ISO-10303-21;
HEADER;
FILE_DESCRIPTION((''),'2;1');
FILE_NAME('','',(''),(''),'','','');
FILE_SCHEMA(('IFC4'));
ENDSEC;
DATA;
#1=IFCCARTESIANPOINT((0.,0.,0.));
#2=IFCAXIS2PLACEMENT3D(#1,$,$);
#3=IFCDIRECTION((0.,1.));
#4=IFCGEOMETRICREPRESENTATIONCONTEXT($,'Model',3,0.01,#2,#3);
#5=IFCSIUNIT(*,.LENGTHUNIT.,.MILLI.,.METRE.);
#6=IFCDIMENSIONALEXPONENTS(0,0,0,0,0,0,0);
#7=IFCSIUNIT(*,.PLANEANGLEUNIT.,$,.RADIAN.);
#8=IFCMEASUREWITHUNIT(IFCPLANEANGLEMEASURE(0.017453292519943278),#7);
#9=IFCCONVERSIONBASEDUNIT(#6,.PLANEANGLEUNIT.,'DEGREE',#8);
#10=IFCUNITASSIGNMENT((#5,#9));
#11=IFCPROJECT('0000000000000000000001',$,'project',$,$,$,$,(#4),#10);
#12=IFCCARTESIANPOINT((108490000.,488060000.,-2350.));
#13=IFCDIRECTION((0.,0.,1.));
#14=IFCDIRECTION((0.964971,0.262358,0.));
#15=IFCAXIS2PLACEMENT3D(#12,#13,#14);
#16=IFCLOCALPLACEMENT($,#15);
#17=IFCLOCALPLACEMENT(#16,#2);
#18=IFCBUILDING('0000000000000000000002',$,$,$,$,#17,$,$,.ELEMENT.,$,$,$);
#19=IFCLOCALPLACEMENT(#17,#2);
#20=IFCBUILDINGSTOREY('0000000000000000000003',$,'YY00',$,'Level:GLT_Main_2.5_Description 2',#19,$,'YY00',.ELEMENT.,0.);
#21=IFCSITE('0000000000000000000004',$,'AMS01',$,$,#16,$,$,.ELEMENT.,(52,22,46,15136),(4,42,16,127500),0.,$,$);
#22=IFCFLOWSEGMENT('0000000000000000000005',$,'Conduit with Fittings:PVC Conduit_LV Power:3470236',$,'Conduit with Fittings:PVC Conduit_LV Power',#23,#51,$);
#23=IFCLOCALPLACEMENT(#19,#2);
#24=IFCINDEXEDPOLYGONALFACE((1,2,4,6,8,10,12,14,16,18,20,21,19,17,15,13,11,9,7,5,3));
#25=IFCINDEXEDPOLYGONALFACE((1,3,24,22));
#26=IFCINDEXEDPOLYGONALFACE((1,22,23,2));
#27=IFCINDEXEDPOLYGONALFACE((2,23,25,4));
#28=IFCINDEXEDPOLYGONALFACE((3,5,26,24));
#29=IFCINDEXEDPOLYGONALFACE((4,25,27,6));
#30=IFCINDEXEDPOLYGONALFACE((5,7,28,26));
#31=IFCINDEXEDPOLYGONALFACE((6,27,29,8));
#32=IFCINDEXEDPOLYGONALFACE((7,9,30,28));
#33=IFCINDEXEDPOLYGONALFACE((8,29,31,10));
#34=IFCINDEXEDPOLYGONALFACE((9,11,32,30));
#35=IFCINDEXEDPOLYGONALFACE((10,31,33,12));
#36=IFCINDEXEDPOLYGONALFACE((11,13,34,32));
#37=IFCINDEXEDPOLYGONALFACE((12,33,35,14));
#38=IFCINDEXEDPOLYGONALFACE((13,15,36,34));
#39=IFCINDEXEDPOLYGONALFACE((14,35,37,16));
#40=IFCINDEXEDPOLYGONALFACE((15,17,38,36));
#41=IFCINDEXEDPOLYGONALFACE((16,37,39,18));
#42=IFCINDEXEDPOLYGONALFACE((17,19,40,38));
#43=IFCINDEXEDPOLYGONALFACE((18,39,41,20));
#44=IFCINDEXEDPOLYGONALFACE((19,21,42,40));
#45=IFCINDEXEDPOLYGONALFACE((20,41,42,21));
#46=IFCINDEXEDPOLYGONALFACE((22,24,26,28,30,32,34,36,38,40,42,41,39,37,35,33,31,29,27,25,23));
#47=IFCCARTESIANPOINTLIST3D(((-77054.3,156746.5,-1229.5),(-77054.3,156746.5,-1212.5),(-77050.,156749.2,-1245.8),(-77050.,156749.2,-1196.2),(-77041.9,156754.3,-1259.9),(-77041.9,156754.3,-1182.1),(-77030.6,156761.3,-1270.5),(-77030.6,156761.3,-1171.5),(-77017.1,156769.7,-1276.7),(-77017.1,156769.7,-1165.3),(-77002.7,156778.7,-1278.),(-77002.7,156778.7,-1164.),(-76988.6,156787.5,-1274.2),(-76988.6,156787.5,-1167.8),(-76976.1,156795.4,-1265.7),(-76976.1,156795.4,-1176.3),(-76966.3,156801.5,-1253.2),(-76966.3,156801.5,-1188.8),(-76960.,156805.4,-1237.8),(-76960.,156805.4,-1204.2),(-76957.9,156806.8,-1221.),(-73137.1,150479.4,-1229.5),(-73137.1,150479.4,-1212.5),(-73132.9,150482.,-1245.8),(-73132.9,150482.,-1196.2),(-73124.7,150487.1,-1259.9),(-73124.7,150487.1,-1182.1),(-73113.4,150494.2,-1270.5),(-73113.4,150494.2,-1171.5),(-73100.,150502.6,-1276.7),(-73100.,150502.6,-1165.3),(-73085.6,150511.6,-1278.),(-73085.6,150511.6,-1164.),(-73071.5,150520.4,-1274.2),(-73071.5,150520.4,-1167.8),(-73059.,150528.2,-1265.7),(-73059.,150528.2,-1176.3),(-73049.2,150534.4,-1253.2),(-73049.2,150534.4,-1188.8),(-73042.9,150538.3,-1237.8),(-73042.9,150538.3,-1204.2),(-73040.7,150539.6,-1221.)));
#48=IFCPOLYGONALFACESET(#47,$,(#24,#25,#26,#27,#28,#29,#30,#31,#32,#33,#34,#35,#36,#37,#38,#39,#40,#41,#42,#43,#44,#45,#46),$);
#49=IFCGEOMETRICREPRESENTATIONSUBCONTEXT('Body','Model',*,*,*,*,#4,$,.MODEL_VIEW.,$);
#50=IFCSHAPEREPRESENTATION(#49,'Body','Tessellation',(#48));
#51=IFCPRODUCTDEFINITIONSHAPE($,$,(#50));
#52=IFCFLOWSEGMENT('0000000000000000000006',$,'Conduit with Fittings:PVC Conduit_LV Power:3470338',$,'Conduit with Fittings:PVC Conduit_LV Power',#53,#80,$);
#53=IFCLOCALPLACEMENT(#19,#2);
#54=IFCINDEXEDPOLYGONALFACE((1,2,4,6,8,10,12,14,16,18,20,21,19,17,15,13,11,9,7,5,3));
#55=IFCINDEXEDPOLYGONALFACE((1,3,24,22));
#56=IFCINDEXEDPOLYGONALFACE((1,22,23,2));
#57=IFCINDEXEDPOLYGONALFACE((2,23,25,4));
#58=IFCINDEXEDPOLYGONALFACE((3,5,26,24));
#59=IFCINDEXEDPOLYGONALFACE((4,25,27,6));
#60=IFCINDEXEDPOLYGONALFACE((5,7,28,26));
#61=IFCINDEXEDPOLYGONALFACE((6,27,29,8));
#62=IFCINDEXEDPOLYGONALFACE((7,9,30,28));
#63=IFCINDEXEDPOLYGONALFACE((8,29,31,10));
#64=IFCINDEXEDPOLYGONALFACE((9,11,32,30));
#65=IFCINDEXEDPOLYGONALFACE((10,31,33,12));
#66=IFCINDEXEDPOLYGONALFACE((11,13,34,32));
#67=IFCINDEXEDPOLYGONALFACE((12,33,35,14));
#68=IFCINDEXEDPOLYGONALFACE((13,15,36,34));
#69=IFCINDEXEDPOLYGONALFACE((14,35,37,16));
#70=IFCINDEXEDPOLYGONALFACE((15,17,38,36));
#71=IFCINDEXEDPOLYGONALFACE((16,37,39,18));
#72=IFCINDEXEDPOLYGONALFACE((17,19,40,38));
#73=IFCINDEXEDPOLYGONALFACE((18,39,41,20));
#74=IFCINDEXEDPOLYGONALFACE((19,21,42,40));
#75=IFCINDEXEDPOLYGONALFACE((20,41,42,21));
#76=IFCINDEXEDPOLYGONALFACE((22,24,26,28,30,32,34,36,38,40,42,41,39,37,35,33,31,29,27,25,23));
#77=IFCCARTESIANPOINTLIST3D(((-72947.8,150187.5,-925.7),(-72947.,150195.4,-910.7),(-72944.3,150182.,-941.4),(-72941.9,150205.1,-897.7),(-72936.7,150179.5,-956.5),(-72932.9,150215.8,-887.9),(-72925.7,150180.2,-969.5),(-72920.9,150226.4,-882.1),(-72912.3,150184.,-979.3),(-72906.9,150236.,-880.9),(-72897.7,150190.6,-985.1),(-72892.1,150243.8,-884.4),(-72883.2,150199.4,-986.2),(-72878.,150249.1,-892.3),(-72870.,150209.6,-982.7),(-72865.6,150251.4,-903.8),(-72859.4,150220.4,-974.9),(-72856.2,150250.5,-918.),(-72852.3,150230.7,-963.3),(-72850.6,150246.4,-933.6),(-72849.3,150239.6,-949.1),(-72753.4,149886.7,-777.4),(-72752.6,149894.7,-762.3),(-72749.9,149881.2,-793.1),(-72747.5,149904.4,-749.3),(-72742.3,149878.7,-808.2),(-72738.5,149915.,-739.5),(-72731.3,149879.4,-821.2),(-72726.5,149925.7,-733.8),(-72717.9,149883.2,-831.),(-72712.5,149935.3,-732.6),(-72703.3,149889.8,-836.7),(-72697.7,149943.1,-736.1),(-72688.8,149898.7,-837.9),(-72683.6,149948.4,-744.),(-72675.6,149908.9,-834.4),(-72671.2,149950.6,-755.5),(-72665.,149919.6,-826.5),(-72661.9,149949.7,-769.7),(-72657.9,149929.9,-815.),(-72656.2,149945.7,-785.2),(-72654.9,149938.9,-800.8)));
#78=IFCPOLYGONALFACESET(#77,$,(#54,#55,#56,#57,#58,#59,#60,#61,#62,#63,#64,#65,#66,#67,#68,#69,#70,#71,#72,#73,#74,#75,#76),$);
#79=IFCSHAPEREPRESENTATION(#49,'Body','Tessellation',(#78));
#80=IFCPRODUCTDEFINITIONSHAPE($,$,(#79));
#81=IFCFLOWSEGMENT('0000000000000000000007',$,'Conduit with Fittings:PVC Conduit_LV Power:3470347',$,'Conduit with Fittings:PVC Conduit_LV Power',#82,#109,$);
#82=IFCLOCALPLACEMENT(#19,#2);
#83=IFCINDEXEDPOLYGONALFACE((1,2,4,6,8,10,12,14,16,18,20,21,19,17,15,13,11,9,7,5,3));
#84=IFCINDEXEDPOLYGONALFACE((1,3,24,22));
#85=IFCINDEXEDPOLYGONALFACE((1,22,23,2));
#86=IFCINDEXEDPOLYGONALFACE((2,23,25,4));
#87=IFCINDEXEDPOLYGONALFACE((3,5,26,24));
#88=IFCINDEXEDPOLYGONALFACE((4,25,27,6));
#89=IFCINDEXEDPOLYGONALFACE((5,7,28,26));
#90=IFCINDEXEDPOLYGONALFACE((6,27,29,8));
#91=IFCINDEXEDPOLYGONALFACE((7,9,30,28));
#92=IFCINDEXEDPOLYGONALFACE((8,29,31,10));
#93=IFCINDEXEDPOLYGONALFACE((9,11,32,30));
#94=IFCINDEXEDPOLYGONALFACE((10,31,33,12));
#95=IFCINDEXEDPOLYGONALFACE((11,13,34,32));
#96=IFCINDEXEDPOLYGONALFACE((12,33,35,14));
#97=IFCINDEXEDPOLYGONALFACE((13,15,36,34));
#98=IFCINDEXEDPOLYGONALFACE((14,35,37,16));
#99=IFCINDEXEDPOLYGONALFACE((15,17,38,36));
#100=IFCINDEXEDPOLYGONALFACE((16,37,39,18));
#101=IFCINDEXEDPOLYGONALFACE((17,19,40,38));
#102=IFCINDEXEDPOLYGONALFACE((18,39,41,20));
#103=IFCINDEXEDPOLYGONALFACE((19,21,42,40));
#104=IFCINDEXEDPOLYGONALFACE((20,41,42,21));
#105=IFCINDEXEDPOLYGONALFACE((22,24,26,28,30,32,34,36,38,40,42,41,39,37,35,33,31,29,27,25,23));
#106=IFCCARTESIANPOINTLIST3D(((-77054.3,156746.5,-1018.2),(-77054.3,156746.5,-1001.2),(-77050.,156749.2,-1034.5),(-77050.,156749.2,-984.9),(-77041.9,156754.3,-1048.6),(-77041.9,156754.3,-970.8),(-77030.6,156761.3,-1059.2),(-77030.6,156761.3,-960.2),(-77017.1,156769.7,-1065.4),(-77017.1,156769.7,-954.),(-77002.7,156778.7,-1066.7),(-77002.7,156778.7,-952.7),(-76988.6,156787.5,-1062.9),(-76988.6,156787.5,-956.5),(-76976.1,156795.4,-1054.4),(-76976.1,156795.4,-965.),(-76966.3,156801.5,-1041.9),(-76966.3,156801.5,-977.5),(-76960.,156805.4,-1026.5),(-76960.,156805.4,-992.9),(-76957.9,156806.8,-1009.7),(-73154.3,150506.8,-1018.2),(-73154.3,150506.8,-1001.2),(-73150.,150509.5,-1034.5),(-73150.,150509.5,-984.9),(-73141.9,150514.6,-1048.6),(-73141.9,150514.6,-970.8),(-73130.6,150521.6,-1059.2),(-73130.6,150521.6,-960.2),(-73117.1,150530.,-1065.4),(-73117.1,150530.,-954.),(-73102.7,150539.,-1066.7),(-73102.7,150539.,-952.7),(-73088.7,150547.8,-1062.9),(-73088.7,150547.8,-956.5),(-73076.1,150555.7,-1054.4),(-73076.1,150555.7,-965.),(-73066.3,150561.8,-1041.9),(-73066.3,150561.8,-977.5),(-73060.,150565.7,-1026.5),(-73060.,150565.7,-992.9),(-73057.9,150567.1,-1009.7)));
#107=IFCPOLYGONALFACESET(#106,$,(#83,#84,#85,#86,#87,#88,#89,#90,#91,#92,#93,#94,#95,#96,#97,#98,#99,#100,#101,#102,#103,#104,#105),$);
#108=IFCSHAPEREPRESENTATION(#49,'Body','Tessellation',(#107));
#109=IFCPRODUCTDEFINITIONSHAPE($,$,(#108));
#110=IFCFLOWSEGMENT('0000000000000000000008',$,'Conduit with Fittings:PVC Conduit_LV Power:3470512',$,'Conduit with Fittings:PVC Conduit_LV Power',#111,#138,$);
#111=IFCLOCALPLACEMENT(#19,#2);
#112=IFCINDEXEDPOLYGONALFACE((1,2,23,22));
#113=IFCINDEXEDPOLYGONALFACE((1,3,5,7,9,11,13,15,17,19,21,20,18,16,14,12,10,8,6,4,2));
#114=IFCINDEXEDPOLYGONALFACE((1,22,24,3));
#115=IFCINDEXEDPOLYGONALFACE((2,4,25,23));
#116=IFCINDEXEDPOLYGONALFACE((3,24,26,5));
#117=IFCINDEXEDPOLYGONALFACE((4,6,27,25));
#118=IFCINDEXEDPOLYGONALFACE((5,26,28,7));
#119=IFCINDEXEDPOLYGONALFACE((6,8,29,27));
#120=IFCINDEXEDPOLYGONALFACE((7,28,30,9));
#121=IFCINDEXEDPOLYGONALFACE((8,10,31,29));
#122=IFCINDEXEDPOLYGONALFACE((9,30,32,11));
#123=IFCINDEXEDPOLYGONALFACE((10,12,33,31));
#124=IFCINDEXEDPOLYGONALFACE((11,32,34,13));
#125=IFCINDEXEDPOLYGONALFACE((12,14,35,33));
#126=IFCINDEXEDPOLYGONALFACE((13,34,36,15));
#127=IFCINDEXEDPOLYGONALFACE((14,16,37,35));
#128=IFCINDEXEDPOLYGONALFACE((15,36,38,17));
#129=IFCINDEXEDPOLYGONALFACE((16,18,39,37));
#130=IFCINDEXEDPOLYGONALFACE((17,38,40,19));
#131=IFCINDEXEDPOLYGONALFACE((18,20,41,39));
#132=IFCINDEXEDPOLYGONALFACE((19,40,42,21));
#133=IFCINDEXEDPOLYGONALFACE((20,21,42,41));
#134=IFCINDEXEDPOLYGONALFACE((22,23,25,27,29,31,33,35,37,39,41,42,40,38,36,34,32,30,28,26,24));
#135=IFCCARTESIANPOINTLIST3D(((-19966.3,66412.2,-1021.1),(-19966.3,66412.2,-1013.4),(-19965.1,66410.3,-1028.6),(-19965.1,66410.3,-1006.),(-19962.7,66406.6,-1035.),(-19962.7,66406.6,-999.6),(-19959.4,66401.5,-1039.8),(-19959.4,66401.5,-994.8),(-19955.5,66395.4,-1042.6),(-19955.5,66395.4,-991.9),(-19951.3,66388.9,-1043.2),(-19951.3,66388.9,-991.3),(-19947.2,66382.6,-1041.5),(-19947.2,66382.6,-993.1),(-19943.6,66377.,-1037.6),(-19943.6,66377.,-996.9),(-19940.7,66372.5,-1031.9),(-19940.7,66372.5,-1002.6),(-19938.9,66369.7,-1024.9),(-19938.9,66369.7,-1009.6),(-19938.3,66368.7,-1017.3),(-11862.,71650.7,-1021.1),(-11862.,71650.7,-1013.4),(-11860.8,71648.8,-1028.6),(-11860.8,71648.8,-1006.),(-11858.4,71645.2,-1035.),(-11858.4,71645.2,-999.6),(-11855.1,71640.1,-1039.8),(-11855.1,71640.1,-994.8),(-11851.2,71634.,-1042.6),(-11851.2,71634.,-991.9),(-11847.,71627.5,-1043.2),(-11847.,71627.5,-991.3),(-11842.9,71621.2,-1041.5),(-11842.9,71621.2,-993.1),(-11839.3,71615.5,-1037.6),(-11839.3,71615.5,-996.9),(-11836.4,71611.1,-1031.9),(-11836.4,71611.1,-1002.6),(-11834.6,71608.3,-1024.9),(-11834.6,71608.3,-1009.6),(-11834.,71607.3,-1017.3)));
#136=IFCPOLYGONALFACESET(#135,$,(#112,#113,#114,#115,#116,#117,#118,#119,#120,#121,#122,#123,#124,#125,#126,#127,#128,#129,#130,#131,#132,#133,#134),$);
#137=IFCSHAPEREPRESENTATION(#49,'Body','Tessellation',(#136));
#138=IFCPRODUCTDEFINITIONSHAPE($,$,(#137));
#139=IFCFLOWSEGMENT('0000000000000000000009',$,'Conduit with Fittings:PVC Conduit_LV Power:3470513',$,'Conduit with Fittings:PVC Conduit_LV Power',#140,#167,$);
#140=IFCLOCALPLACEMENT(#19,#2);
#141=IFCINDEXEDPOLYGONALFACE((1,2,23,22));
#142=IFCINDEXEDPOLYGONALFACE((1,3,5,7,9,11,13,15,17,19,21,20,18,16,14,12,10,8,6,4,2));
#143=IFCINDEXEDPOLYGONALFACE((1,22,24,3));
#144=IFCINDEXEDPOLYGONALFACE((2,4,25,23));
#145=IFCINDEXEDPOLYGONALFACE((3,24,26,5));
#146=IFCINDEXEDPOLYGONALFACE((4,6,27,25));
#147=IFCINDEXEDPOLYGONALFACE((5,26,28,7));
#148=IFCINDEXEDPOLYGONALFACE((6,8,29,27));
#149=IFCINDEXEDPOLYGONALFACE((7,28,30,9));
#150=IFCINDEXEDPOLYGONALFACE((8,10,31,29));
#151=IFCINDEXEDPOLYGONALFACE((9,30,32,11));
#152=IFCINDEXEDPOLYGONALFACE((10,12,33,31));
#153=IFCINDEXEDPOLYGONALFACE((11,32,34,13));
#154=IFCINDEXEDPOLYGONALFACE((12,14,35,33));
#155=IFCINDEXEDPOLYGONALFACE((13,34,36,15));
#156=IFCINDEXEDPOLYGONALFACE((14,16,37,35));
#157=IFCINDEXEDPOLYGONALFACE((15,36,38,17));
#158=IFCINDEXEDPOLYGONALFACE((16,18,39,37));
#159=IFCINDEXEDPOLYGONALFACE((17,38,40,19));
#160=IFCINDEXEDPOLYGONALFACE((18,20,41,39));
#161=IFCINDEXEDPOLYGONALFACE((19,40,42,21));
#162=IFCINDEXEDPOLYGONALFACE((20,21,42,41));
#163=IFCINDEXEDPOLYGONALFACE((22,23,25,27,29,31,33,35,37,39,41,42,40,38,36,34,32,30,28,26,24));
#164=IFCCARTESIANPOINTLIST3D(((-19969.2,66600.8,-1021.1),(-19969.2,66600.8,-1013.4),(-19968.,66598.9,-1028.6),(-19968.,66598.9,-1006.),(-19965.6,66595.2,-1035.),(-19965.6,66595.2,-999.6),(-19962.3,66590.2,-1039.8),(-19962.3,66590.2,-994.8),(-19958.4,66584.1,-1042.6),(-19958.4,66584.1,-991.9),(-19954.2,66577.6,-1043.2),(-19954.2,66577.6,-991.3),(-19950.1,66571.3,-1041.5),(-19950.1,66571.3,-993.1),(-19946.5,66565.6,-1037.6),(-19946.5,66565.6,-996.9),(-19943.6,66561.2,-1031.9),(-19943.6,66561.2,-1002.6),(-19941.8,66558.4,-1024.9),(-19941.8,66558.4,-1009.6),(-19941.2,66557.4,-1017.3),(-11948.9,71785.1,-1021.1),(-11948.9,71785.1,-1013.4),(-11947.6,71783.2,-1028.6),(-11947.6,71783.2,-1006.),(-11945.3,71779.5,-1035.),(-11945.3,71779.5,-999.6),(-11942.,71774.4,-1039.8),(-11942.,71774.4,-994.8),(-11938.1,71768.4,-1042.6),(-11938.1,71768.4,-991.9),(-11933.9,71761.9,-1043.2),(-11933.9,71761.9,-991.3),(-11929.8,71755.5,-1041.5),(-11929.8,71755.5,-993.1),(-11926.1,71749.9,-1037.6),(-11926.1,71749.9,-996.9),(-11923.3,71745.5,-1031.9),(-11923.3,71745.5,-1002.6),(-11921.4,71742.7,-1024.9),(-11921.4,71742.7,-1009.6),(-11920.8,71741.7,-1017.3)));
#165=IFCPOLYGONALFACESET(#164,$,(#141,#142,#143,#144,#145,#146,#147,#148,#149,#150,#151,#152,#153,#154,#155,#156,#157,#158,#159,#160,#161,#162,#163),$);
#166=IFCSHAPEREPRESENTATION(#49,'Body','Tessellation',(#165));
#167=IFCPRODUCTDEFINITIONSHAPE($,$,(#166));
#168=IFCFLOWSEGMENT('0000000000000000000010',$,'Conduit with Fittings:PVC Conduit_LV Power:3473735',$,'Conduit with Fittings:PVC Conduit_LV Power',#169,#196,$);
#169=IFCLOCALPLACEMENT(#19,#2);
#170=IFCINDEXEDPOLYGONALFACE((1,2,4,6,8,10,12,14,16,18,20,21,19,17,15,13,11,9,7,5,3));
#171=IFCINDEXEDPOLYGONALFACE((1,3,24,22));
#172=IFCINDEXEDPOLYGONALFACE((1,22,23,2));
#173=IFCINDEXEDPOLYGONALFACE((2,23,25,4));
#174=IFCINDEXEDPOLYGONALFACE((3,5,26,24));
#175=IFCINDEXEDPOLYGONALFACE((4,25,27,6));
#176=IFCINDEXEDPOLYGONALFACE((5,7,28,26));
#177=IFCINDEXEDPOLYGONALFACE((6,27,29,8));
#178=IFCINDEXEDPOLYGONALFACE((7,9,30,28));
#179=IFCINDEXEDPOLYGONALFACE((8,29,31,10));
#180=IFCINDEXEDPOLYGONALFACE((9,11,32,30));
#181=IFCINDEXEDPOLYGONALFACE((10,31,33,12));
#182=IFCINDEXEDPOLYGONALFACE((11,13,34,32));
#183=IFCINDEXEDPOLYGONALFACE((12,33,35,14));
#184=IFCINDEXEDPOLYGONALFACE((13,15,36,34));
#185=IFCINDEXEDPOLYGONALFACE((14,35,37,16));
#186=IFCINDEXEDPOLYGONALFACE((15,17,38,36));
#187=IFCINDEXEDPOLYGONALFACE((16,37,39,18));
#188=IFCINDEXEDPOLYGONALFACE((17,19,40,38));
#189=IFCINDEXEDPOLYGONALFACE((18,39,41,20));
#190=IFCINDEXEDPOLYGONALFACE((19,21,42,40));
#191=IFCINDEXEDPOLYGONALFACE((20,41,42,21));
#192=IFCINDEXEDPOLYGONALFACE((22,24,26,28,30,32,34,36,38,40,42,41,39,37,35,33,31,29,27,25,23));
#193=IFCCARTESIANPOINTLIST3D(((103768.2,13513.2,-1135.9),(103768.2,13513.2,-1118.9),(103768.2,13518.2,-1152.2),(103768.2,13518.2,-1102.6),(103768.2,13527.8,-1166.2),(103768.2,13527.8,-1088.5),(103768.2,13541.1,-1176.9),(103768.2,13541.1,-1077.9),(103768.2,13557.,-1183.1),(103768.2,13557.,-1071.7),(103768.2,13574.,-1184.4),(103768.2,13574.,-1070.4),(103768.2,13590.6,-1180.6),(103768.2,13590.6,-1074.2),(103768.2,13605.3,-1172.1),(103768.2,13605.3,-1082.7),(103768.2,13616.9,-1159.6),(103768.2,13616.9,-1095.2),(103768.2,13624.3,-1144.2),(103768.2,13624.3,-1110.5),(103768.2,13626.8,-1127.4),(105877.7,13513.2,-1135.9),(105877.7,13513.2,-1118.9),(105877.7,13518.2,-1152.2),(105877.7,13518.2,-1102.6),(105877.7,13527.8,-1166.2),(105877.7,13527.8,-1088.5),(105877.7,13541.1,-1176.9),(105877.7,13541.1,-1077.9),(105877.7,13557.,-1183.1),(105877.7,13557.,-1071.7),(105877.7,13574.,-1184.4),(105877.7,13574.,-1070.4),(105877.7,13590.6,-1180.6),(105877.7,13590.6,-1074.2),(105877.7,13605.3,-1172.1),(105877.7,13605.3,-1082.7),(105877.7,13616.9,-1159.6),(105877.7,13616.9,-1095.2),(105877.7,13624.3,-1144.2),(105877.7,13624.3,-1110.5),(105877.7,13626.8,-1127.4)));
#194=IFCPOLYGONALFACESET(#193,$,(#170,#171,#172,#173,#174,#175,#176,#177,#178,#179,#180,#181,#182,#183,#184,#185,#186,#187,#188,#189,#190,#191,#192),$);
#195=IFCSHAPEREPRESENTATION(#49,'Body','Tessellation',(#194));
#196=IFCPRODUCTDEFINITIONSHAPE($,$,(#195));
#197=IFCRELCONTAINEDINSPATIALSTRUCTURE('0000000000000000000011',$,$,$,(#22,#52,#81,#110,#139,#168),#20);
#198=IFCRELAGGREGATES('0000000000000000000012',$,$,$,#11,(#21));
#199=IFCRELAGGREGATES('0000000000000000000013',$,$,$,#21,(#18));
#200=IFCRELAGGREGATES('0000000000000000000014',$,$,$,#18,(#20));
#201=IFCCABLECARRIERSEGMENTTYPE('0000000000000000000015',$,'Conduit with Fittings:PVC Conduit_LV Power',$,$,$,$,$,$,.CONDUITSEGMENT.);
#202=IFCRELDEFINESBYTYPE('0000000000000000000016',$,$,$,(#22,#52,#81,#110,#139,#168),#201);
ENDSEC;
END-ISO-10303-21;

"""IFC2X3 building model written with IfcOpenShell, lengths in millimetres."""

from ifc_helpers import new_model, entity, si_unit, converted_unit, direction, frame, frame_2d, origin, origin_2d_with_axis, place, context, subcontext, project, spatial, circle, extrude, type_object, element, save


model = new_model("IFC2X3")

# Units and contexts
model_context = context("Model", 3, precision=0.01, world=origin(), true_north=direction((0.0, 1.0)))
body_context = subcontext(model_context, "Body", "Model", "MODEL_VIEW")
ifc_project = project(units=[si_unit("LENGTHUNIT", "METRE", prefix="MILLI"), converted_unit("PLANEANGLEUNIT", "DEGREE", entity("IfcPlaneAngleMeasure", 0.017453292519943278), si_unit("PLANEANGLEUNIT", "RADIAN"), dimensions=[0, 0, 0, 0, 0, 0, 0])], contexts=[model_context])

# Site, building, storey
site_placement = place(None, frame((108490000.0, 488060000.0, -2350.0), z_axis=(0.0, 0.0, 1.0), x_axis=(0.964971, 0.262358, 0.0)))
site = spatial("IfcSite", under=ifc_project, at=site_placement, Name="AMS01", CompositionType="ELEMENT", RefLatitude=(52, 22, 46, 15136), RefLongitude=(4, 42, 16, 127500), RefElevation=0.0)
building_placement = place(site_placement, origin())
building = spatial("IfcBuilding", under=site, at=building_placement, CompositionType="ELEMENT")
storey_placement = place(building_placement, origin())
storey = spatial("IfcBuildingStorey", under=building, at=storey_placement, Name="YY00", ObjectType="Level:GLT_Main_2.5_Description 2", LongName="YY00", CompositionType="ELEMENT", Elevation=0.0)

# Flow segments
cable_carrier_segment_type = type_object("IfcCableCarrierSegmentType", Name="Conduit with Fittings:PVC Conduit_LV Power", PredefinedType="CONDUITSEGMENT")
flow_segment_1_placement = place(storey_placement, origin())
element("IfcFlowSegment", 1, at=flow_segment_1_placement, inside=storey, type_object=cable_carrier_segment_type, Name="Conduit with Fittings:PVC Conduit_LV Power:3470236", ObjectType="Conduit with Fittings:PVC Conduit_LV Power", context=body_context, shape_type="SweptSolid", body=[
    extrude(circle(Radius=57.2, at=origin_2d_with_axis()), frame((-73089.2, 150509.3, -1221.0), z_axis=(-0.530017, 0.847987, 0.0), x_axis=(0.847987, 0.530017, 0.0)), (0.0, 0.0, 1.0), 7390.6),
])
flow_segment_2_placement = place(storey_placement, origin())
element("IfcFlowSegment", 2, at=flow_segment_2_placement, inside=storey, type_object=cable_carrier_segment_type, Name="Conduit with Fittings:PVC Conduit_LV Power:3470338", ObjectType="Conduit with Fittings:PVC Conduit_LV Power", context=body_context, shape_type="SweptSolid", body=[
    extrude(circle(Radius=57.2, at=frame_2d((0.0, 0.0), x_axis=(1.0, 0.0))), frame((-72898.6, 150215.4, -933.6), z_axis=(0.501534, -0.775898, 0.382683), x_axis=(0.839826, 0.542856, 0.0)), (0.0, 0.0, 1.0), 387.6),
])
flow_segment_3_placement = place(storey_placement, origin())
element("IfcFlowSegment", 3, at=flow_segment_3_placement, inside=storey, type_object=cable_carrier_segment_type, Name="Conduit with Fittings:PVC Conduit_LV Power:3470347", ObjectType="Conduit with Fittings:PVC Conduit_LV Power", context=body_context, shape_type="SweptSolid", body=[
    extrude(circle(Radius=57.2, at=origin_2d_with_axis()), frame((-73106.4, 150536.8, -1009.7), z_axis=(-0.530017, 0.847987, 0.0), x_axis=(0.847987, 0.530017, 0.0)), (0.0, 0.0, 1.0), 7358.2),
])
flow_segment_4_placement = place(storey_placement, origin())
element("IfcFlowSegment", 4, at=flow_segment_4_placement, inside=storey, type_object=cable_carrier_segment_type, Name="Conduit with Fittings:PVC Conduit_LV Power:3470512", ObjectType="Conduit with Fittings:PVC Conduit_LV Power", context=body_context, shape_type="SweptSolid", body=[
    extrude(circle(Radius=26.0, at=origin_2d_with_axis()), frame((-19952.4, 66390.6, -1017.3), z_axis=(0.839826, 0.542856, 0.0), x_axis=(0.542856, -0.839826, 0.0)), (0.0, 0.0, 1.0), 9650.0),
])
flow_segment_5_placement = place(storey_placement, origin())
element("IfcFlowSegment", 5, at=flow_segment_5_placement, inside=storey, type_object=cable_carrier_segment_type, Name="Conduit with Fittings:PVC Conduit_LV Power:3470513", ObjectType="Conduit with Fittings:PVC Conduit_LV Power", context=body_context, shape_type="SweptSolid", body=[
    extrude(circle(Radius=26.0, at=origin_2d_with_axis()), frame((-19955.3, 66579.2, -1017.3), z_axis=(0.839826, 0.542856, 0.0), x_axis=(0.542856, -0.839826, 0.0)), (0.0, 0.0, 1.0), 9550.0),
])
flow_segment_6_placement = place(storey_placement, origin())
element("IfcFlowSegment", 6, at=flow_segment_6_placement, inside=storey, type_object=cable_carrier_segment_type, Name="Conduit with Fittings:PVC Conduit_LV Power:3473735", ObjectType="Conduit with Fittings:PVC Conduit_LV Power", context=body_context, shape_type="SweptSolid", body=[
    extrude(circle(Radius=57.2, at=frame_2d((0.0, 0.0), x_axis=(1.0, 0.0))), frame((103768.2, 13569.7, -1127.4), z_axis=(1.0, 0.0, 0.0), x_axis=(0.0, 1.0, 0.0)), (0.0, 0.0, 1.0), 2109.5),
])

save(model, "model.ifc")
